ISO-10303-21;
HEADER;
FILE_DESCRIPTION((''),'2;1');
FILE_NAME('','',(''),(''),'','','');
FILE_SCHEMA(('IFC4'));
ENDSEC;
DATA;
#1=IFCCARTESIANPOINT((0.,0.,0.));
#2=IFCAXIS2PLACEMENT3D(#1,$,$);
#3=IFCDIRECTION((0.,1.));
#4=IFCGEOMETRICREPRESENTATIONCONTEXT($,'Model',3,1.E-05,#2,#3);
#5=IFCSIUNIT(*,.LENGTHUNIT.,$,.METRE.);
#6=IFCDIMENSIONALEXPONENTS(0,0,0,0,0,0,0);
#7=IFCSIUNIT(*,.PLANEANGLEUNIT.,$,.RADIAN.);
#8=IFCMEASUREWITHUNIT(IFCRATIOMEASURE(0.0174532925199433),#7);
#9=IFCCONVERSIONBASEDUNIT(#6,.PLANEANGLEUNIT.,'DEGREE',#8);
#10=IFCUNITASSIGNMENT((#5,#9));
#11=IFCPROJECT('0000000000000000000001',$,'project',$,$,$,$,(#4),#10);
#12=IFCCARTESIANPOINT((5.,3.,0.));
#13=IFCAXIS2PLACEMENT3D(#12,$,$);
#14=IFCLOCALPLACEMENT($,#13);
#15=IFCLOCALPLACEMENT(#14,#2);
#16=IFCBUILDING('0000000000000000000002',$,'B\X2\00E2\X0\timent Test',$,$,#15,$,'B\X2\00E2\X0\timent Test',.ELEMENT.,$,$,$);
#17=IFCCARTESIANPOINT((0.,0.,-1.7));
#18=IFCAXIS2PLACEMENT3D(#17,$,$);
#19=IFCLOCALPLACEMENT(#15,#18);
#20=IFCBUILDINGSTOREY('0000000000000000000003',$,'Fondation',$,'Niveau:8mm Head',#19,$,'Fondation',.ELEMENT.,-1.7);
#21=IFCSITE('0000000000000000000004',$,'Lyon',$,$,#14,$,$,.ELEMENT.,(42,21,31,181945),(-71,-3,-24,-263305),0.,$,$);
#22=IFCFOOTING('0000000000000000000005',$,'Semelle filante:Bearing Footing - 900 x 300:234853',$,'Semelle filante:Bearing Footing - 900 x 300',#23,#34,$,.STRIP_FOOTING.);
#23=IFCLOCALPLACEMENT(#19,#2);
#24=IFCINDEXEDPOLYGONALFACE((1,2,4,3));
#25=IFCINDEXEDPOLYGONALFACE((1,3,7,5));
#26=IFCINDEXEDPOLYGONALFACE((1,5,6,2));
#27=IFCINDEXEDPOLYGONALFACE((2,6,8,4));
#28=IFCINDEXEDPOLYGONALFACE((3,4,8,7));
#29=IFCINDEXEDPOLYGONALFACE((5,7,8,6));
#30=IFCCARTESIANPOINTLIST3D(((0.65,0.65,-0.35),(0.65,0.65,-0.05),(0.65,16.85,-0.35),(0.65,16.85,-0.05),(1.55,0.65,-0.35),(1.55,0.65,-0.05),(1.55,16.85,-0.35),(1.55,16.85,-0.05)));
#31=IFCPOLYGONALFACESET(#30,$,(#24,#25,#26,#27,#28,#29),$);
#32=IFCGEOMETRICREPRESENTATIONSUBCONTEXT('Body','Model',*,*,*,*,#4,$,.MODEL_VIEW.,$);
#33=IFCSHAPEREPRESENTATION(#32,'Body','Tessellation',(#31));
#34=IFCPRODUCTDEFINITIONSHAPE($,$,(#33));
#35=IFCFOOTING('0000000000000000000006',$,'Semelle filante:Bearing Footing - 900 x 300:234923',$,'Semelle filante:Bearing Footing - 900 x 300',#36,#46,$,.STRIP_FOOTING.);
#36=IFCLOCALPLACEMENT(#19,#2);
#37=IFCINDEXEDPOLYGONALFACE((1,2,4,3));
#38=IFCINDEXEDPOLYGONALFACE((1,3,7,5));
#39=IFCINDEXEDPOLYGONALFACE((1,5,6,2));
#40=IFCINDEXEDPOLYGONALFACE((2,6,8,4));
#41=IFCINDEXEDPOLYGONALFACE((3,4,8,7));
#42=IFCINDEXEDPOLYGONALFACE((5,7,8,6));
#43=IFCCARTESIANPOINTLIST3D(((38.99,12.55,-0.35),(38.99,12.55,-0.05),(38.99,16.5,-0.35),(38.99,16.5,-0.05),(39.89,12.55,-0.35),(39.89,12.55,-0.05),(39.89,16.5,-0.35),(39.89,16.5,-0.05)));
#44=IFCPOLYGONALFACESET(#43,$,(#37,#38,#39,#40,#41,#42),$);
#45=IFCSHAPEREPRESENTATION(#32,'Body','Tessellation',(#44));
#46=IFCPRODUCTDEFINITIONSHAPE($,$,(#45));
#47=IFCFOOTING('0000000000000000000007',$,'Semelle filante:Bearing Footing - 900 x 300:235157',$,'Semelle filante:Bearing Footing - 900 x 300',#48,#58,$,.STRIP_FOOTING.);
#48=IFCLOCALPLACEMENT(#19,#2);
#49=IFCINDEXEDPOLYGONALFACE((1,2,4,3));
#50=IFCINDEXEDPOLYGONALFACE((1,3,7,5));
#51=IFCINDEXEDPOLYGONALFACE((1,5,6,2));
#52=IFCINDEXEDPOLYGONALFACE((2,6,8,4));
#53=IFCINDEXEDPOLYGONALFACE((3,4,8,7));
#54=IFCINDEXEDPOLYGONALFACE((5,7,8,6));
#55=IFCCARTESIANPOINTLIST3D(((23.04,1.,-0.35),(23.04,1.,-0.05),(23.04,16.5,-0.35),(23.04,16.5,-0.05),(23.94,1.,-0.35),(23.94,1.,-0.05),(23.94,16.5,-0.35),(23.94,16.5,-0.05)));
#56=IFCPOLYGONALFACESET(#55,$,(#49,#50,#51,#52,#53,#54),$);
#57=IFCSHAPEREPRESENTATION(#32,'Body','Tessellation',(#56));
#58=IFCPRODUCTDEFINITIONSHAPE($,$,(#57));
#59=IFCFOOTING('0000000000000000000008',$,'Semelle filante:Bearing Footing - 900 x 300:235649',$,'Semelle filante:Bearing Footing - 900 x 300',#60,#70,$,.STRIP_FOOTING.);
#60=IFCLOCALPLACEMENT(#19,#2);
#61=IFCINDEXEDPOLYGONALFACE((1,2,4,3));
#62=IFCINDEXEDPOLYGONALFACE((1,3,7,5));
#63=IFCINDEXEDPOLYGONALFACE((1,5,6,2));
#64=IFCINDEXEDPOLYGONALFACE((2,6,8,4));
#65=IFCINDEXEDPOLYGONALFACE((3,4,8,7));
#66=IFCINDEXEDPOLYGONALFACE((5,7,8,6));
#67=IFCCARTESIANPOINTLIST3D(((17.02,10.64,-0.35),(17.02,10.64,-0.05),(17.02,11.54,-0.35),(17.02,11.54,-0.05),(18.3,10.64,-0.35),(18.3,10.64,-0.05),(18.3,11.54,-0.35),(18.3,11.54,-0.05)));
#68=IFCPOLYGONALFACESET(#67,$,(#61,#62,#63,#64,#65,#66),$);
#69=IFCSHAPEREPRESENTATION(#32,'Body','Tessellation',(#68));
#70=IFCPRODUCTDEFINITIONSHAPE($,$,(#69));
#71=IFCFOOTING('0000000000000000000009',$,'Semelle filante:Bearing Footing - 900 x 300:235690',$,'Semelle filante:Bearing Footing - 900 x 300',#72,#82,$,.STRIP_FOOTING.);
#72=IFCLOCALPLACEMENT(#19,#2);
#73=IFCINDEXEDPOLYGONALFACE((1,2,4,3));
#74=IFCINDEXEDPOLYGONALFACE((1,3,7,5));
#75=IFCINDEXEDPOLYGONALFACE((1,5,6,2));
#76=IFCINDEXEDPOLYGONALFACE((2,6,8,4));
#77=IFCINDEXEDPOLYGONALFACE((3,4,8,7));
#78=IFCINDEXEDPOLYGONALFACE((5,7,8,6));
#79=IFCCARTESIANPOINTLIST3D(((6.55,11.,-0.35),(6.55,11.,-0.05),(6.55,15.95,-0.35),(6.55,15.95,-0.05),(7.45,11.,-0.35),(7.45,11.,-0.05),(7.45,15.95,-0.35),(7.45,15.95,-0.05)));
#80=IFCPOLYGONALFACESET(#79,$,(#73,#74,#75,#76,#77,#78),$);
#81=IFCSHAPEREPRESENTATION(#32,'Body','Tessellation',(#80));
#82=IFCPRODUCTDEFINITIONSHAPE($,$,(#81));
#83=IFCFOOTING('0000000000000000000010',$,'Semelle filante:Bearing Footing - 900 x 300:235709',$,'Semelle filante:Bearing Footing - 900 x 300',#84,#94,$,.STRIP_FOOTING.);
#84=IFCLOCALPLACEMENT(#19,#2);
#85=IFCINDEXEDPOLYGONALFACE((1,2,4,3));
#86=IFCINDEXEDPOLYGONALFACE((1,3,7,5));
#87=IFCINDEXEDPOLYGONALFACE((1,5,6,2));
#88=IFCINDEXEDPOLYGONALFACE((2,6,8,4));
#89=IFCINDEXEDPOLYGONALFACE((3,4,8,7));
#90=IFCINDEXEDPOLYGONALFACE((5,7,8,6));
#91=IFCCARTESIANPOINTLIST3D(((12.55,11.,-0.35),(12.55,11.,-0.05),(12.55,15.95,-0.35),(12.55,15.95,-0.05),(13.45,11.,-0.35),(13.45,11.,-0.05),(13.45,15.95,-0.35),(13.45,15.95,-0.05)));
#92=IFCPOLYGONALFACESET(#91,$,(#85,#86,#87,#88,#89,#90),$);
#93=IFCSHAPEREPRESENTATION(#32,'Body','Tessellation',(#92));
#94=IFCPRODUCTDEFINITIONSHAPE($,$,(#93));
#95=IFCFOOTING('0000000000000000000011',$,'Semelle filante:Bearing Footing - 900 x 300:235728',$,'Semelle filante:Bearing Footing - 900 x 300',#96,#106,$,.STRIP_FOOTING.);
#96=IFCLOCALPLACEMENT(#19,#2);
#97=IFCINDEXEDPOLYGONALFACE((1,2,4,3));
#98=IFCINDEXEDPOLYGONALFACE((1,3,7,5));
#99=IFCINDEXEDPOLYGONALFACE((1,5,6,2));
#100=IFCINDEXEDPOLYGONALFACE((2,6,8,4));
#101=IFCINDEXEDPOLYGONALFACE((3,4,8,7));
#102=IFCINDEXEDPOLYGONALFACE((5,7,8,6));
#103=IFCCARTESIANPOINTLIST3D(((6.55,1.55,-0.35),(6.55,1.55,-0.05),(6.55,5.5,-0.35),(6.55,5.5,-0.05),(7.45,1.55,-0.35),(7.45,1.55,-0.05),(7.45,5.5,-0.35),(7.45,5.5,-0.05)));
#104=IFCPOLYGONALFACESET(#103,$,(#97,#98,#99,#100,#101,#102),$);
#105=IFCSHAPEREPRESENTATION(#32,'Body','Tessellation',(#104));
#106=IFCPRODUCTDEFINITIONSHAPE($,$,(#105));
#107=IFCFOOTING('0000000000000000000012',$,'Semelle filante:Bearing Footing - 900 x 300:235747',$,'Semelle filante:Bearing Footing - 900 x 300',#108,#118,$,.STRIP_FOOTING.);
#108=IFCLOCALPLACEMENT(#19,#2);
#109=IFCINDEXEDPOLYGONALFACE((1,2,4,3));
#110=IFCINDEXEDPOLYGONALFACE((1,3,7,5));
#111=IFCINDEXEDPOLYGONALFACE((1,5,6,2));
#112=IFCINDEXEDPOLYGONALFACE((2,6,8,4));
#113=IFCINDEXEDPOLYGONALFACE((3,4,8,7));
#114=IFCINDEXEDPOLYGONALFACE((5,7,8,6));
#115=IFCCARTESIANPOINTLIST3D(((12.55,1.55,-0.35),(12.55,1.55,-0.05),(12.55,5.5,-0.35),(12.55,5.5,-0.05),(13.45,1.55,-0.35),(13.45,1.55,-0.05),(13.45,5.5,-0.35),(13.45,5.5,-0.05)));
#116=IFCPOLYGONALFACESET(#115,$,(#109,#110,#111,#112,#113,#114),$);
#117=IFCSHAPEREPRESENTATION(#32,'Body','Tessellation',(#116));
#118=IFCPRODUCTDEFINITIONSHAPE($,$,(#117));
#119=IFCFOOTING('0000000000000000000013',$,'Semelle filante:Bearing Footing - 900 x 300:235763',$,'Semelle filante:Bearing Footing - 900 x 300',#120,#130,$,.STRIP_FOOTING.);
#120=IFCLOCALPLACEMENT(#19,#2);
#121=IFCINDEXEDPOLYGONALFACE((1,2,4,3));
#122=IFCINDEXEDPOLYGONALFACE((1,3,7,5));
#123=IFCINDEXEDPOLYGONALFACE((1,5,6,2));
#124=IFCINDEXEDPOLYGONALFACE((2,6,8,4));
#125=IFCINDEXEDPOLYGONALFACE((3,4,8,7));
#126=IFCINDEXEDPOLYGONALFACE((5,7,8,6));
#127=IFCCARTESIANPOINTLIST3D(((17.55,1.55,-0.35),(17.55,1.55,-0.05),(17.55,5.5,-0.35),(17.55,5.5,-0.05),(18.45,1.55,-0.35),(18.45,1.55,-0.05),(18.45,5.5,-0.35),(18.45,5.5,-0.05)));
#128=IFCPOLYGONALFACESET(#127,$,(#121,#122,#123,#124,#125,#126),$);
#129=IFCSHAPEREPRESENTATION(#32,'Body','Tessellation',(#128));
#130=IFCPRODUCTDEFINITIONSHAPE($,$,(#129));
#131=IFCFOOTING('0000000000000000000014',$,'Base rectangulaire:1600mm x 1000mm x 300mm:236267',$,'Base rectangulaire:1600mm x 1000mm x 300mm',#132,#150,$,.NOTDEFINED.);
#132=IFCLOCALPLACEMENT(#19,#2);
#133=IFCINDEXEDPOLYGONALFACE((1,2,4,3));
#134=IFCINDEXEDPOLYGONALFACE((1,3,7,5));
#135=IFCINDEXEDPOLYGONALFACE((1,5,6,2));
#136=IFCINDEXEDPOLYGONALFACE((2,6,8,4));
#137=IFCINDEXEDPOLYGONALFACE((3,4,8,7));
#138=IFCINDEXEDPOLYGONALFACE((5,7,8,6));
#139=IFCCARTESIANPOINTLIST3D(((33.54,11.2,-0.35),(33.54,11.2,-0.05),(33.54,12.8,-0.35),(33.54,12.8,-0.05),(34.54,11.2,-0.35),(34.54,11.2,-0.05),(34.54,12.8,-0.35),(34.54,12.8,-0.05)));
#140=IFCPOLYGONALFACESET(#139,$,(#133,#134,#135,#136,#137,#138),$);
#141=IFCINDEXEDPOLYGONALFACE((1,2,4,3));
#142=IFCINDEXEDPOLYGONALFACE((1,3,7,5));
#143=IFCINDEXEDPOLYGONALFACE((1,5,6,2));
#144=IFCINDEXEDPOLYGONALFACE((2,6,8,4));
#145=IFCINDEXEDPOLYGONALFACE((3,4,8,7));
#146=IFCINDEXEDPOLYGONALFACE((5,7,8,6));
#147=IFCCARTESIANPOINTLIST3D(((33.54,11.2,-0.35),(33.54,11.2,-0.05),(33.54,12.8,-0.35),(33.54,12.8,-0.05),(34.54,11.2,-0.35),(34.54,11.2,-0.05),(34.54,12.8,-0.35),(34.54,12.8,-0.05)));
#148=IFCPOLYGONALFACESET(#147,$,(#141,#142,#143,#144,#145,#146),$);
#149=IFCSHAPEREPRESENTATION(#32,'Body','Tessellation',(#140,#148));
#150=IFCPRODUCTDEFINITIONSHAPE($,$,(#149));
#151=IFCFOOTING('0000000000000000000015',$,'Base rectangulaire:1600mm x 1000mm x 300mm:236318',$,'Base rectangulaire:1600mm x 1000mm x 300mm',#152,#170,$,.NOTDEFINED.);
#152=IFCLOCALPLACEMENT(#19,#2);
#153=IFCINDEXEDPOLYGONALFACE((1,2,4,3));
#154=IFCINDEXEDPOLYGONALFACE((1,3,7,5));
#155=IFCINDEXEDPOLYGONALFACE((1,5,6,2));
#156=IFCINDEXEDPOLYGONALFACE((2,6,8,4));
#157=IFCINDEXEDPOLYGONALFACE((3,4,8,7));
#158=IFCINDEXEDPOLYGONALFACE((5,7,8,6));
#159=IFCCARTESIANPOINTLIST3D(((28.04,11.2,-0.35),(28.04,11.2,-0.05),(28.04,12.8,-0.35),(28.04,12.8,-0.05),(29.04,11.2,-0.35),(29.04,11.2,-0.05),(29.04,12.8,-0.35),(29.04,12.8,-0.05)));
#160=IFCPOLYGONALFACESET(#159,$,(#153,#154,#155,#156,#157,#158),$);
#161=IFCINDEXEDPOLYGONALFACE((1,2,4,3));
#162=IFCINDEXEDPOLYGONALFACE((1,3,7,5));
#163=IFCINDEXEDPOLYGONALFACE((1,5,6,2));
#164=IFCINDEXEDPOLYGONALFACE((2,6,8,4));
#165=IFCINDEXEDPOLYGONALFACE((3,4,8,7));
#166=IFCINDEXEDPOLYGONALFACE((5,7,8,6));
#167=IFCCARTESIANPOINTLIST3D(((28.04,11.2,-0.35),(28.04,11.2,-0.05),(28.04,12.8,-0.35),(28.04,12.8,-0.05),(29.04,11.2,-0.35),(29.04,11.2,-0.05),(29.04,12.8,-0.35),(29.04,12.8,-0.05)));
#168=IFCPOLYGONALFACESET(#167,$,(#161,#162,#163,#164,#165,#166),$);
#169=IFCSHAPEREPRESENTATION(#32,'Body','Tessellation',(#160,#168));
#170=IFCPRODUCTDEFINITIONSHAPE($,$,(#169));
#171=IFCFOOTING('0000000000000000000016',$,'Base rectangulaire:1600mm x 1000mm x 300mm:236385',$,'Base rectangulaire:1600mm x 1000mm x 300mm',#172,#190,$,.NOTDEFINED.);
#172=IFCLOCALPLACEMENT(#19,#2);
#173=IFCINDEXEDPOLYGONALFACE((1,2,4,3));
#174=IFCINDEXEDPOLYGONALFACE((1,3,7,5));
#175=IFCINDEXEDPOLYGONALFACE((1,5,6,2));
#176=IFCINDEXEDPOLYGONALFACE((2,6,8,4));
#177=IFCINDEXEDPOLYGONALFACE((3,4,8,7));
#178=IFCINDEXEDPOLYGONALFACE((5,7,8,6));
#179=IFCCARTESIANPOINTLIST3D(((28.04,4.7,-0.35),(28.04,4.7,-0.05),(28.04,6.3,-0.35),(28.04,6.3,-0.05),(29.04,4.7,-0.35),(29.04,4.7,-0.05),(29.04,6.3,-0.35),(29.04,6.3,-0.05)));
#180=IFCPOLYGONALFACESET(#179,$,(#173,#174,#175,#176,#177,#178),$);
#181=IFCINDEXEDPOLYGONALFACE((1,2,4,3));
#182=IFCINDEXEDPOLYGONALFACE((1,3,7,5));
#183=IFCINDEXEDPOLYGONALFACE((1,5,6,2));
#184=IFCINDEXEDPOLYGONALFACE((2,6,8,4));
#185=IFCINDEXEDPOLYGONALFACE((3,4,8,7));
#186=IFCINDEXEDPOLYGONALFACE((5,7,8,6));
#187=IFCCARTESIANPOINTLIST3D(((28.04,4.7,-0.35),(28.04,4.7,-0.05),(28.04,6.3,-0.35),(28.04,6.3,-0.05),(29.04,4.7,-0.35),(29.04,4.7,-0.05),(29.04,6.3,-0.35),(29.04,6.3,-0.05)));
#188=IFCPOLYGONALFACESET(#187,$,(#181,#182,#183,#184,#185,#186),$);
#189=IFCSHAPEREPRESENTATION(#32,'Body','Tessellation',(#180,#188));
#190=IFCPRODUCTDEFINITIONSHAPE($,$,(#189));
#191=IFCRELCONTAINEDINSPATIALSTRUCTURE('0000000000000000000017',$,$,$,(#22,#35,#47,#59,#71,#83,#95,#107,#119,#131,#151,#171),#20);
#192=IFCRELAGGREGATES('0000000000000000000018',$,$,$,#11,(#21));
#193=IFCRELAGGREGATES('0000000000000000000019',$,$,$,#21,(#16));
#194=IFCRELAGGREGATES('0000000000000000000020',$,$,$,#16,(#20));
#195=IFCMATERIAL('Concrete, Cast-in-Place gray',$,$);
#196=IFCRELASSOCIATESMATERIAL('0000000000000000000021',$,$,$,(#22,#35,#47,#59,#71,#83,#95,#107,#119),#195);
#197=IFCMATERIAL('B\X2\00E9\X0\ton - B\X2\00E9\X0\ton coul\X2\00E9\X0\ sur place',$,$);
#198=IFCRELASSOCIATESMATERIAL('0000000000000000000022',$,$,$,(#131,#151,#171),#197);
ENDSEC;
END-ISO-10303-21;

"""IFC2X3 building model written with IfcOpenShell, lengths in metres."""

from ifc_helpers import new_model, entity, si_unit, converted_unit, direction, frame, frame_2d, origin, origin_2d_with_axis, place, context, subcontext, project, spatial, rectangle, extrude, material, element, save


model = new_model("IFC2X3")

# Units and contexts
model_context = context("Model", 3, precision=1e-05, world=origin(), true_north=direction((0.0, 1.0)))
body_context = subcontext(model_context, "Body", "Model", "MODEL_VIEW")
ifc_project = project(units=[si_unit("LENGTHUNIT", "METRE"), converted_unit("PLANEANGLEUNIT", "DEGREE", entity("IfcRatioMeasure", 0.0174532925199433), si_unit("PLANEANGLEUNIT", "RADIAN"), dimensions=[0, 0, 0, 0, 0, 0, 0])], contexts=[model_context])

# Site, building, storey
site_placement = place(None, frame((5.0, 3.0, 0.0)))
site = spatial("IfcSite", under=ifc_project, at=site_placement, Name="Lyon", CompositionType="ELEMENT", RefLatitude=(42, 21, 31, 181945), RefLongitude=(-71, -3, -24, -263305), RefElevation=0.0)
building_placement = place(site_placement, origin())
building = spatial("IfcBuilding", under=site, at=building_placement, Name="Bâtiment Test", LongName="Bâtiment Test", CompositionType="ELEMENT")
storey_placement = place(building_placement, frame((0.0, 0.0, -1.7)))
storey = spatial("IfcBuildingStorey", under=building, at=storey_placement, Name="Fondation", ObjectType="Niveau:8mm Head", LongName="Fondation", CompositionType="ELEMENT", Elevation=-1.7)

# Footings
ifc_material_1 = material(Name="Concrete, Cast-in-Place gray")
footing_1_placement = place(storey_placement, origin())
element("IfcFooting", 1, at=footing_1_placement, inside=storey, material=ifc_material_1, Name="Semelle filante:Bearing Footing - 900 x 300:234853", ObjectType="Semelle filante:Bearing Footing - 900 x 300", PredefinedType="STRIP_FOOTING", context=body_context, shape_type="SweptSolid", body=[
    extrude(rectangle(XDim=16.2, YDim=0.9, at=frame_2d((0.0, -0.15), x_axis=(1.0, 0.0))), frame((1.25, 8.75, -0.35), z_axis=(0.0, 0.0, 1.0), x_axis=(0.0, -1.0, 0.0)), (0.0, 0.0, 1.0), 0.3),
])
footing_2_placement = place(storey_placement, origin())
element("IfcFooting", 2, at=footing_2_placement, inside=storey, material=ifc_material_1, Name="Semelle filante:Bearing Footing - 900 x 300:234923", ObjectType="Semelle filante:Bearing Footing - 900 x 300", PredefinedType="STRIP_FOOTING", context=body_context, shape_type="SweptSolid", body=[
    extrude(rectangle(XDim=3.95, YDim=0.9, at=frame_2d((0.0, 0.0), x_axis=(1.0, 0.0))), frame((39.44, 14.525, -0.35), z_axis=(0.0, 0.0, 1.0), x_axis=(0.0, -1.0, 0.0)), (0.0, 0.0, 1.0), 0.3),
])
footing_3_placement = place(storey_placement, origin())
element("IfcFooting", 3, at=footing_3_placement, inside=storey, material=ifc_material_1, Name="Semelle filante:Bearing Footing - 900 x 300:235157", ObjectType="Semelle filante:Bearing Footing - 900 x 300", PredefinedType="STRIP_FOOTING", context=body_context, shape_type="SweptSolid", body=[
    extrude(rectangle(XDim=15.5, YDim=0.9, at=frame_2d((0.0, 0.0), x_axis=(1.0, 0.0))), frame((23.49, 8.75, -0.35), z_axis=(0.0, 0.0, 1.0), x_axis=(0.0, 1.0, 0.0)), (0.0, 0.0, 1.0), 0.3),
])
footing_4_placement = place(storey_placement, origin())
element("IfcFooting", 4, at=footing_4_placement, inside=storey, material=ifc_material_1, Name="Semelle filante:Bearing Footing - 900 x 300:235649", ObjectType="Semelle filante:Bearing Footing - 900 x 300", PredefinedType="STRIP_FOOTING", context=body_context, shape_type="SweptSolid", body=[
    extrude(rectangle(XDim=1.28, YDim=0.9, at=frame_2d((0.0, 0.0), x_axis=(1.0, 0.0))), frame((17.66, 11.09, -0.35), z_axis=(0.0, 0.0, 1.0), x_axis=(-1.0, 0.0, 0.0)), (0.0, 0.0, 1.0), 0.3),
])
footing_5_placement = place(storey_placement, origin())
element("IfcFooting", 5, at=footing_5_placement, inside=storey, material=ifc_material_1, Name="Semelle filante:Bearing Footing - 900 x 300:235690", ObjectType="Semelle filante:Bearing Footing - 900 x 300", PredefinedType="STRIP_FOOTING", context=body_context, shape_type="SweptSolid", body=[
    extrude(rectangle(XDim=4.95, YDim=0.9, at=origin_2d_with_axis()), frame((7.0, 13.475, -0.35), z_axis=(0.0, 0.0, 1.0), x_axis=(0.0, 1.0, 0.0)), (0.0, 0.0, 1.0), 0.3),
])
footing_6_placement = place(storey_placement, origin())
element("IfcFooting", 6, at=footing_6_placement, inside=storey, material=ifc_material_1, Name="Semelle filante:Bearing Footing - 900 x 300:235709", ObjectType="Semelle filante:Bearing Footing - 900 x 300", PredefinedType="STRIP_FOOTING", context=body_context, shape_type="SweptSolid", body=[
    extrude(rectangle(XDim=4.95, YDim=0.9, at=origin_2d_with_axis()), frame((13.0, 13.475, -0.35), z_axis=(0.0, 0.0, 1.0), x_axis=(0.0, 1.0, 0.0)), (0.0, 0.0, 1.0), 0.3),
])
footing_7_placement = place(storey_placement, origin())
element("IfcFooting", 7, at=footing_7_placement, inside=storey, material=ifc_material_1, Name="Semelle filante:Bearing Footing - 900 x 300:235728", ObjectType="Semelle filante:Bearing Footing - 900 x 300", PredefinedType="STRIP_FOOTING", context=body_context, shape_type="SweptSolid", body=[
    extrude(rectangle(XDim=3.95, YDim=0.9, at=frame_2d((0.0, 0.0), x_axis=(1.0, 0.0))), frame((7.0, 3.525, -0.35), z_axis=(0.0, 0.0, 1.0), x_axis=(0.0, -1.0, 0.0)), (0.0, 0.0, 1.0), 0.3),
])
footing_8_placement = place(storey_placement, origin())
element("IfcFooting", 8, at=footing_8_placement, inside=storey, material=ifc_material_1, Name="Semelle filante:Bearing Footing - 900 x 300:235747", ObjectType="Semelle filante:Bearing Footing - 900 x 300", PredefinedType="STRIP_FOOTING", context=body_context, shape_type="SweptSolid", body=[
    extrude(rectangle(XDim=3.95, YDim=0.9, at=frame_2d((0.0, 0.0), x_axis=(1.0, 0.0))), frame((13.0, 3.525, -0.35), z_axis=(0.0, 0.0, 1.0), x_axis=(0.0, -1.0, 0.0)), (0.0, 0.0, 1.0), 0.3),
])
footing_9_placement = place(storey_placement, origin())
element("IfcFooting", 9, at=footing_9_placement, inside=storey, material=ifc_material_1, Name="Semelle filante:Bearing Footing - 900 x 300:235763", ObjectType="Semelle filante:Bearing Footing - 900 x 300", PredefinedType="STRIP_FOOTING", context=body_context, shape_type="SweptSolid", body=[
    extrude(rectangle(XDim=3.95, YDim=0.9, at=frame_2d((0.0, 0.0), x_axis=(1.0, 0.0))), frame((18.0, 3.525, -0.35), z_axis=(0.0, 0.0, 1.0), x_axis=(0.0, -1.0, 0.0)), (0.0, 0.0, 1.0), 0.3),
])
ifc_material_2 = material(Name="Béton - Béton coulé sur place")
footing_10_placement = place(storey_placement, origin())
element("IfcFooting", 10, at=footing_10_placement, inside=storey, material=ifc_material_2, Name="Base rectangulaire:1600mm x 1000mm x 300mm:236267", ObjectType="Base rectangulaire:1600mm x 1000mm x 300mm", PredefinedType="NOTDEFINED", context=body_context, shape_type="SweptSolid", body=[
    extrude(rectangle(XDim=1.0, YDim=1.6, at=origin_2d_with_axis()), frame((34.04, 12.0, -0.35), z_axis=(0.0, 0.0, 1.0), x_axis=(-1.0, 0.0, 0.0)), (0.0, 0.0, 1.0), 0.3),
    extrude(rectangle(XDim=1.0, YDim=1.6, at=origin_2d_with_axis()), frame((34.04, 12.0, -0.35), z_axis=(0.0, 0.0, 1.0), x_axis=(-1.0, 0.0, 0.0)), (0.0, 0.0, 1.0), 0.3),
])
footing_11_placement = place(storey_placement, origin())
element("IfcFooting", 11, at=footing_11_placement, inside=storey, material=ifc_material_2, Name="Base rectangulaire:1600mm x 1000mm x 300mm:236318", ObjectType="Base rectangulaire:1600mm x 1000mm x 300mm", PredefinedType="NOTDEFINED", context=body_context, shape_type="SweptSolid", body=[
    extrude(rectangle(XDim=1.0, YDim=1.6, at=origin_2d_with_axis()), frame((28.54, 12.0, -0.35), z_axis=(0.0, 0.0, 1.0), x_axis=(-1.0, 0.0, 0.0)), (0.0, 0.0, 1.0), 0.3),
    extrude(rectangle(XDim=1.0, YDim=1.6, at=origin_2d_with_axis()), frame((28.54, 12.0, -0.35), z_axis=(0.0, 0.0, 1.0), x_axis=(-1.0, 0.0, 0.0)), (0.0, 0.0, 1.0), 0.3),
])
footing_12_placement = place(storey_placement, origin())
element("IfcFooting", 12, at=footing_12_placement, inside=storey, material=ifc_material_2, Name="Base rectangulaire:1600mm x 1000mm x 300mm:236385", ObjectType="Base rectangulaire:1600mm x 1000mm x 300mm", PredefinedType="NOTDEFINED", context=body_context, shape_type="SweptSolid", body=[
    extrude(rectangle(XDim=1.0, YDim=1.6, at=origin_2d_with_axis()), frame((28.54, 5.5, -0.35), z_axis=(0.0, 0.0, 1.0), x_axis=(-1.0, 0.0, 0.0)), (0.0, 0.0, 1.0), 0.3),
    extrude(rectangle(XDim=1.0, YDim=1.6, at=origin_2d_with_axis()), frame((28.54, 5.5, -0.35), z_axis=(0.0, 0.0, 1.0), x_axis=(-1.0, 0.0, 0.0)), (0.0, 0.0, 1.0), 0.3),
])

save(model, "model.ifc")
